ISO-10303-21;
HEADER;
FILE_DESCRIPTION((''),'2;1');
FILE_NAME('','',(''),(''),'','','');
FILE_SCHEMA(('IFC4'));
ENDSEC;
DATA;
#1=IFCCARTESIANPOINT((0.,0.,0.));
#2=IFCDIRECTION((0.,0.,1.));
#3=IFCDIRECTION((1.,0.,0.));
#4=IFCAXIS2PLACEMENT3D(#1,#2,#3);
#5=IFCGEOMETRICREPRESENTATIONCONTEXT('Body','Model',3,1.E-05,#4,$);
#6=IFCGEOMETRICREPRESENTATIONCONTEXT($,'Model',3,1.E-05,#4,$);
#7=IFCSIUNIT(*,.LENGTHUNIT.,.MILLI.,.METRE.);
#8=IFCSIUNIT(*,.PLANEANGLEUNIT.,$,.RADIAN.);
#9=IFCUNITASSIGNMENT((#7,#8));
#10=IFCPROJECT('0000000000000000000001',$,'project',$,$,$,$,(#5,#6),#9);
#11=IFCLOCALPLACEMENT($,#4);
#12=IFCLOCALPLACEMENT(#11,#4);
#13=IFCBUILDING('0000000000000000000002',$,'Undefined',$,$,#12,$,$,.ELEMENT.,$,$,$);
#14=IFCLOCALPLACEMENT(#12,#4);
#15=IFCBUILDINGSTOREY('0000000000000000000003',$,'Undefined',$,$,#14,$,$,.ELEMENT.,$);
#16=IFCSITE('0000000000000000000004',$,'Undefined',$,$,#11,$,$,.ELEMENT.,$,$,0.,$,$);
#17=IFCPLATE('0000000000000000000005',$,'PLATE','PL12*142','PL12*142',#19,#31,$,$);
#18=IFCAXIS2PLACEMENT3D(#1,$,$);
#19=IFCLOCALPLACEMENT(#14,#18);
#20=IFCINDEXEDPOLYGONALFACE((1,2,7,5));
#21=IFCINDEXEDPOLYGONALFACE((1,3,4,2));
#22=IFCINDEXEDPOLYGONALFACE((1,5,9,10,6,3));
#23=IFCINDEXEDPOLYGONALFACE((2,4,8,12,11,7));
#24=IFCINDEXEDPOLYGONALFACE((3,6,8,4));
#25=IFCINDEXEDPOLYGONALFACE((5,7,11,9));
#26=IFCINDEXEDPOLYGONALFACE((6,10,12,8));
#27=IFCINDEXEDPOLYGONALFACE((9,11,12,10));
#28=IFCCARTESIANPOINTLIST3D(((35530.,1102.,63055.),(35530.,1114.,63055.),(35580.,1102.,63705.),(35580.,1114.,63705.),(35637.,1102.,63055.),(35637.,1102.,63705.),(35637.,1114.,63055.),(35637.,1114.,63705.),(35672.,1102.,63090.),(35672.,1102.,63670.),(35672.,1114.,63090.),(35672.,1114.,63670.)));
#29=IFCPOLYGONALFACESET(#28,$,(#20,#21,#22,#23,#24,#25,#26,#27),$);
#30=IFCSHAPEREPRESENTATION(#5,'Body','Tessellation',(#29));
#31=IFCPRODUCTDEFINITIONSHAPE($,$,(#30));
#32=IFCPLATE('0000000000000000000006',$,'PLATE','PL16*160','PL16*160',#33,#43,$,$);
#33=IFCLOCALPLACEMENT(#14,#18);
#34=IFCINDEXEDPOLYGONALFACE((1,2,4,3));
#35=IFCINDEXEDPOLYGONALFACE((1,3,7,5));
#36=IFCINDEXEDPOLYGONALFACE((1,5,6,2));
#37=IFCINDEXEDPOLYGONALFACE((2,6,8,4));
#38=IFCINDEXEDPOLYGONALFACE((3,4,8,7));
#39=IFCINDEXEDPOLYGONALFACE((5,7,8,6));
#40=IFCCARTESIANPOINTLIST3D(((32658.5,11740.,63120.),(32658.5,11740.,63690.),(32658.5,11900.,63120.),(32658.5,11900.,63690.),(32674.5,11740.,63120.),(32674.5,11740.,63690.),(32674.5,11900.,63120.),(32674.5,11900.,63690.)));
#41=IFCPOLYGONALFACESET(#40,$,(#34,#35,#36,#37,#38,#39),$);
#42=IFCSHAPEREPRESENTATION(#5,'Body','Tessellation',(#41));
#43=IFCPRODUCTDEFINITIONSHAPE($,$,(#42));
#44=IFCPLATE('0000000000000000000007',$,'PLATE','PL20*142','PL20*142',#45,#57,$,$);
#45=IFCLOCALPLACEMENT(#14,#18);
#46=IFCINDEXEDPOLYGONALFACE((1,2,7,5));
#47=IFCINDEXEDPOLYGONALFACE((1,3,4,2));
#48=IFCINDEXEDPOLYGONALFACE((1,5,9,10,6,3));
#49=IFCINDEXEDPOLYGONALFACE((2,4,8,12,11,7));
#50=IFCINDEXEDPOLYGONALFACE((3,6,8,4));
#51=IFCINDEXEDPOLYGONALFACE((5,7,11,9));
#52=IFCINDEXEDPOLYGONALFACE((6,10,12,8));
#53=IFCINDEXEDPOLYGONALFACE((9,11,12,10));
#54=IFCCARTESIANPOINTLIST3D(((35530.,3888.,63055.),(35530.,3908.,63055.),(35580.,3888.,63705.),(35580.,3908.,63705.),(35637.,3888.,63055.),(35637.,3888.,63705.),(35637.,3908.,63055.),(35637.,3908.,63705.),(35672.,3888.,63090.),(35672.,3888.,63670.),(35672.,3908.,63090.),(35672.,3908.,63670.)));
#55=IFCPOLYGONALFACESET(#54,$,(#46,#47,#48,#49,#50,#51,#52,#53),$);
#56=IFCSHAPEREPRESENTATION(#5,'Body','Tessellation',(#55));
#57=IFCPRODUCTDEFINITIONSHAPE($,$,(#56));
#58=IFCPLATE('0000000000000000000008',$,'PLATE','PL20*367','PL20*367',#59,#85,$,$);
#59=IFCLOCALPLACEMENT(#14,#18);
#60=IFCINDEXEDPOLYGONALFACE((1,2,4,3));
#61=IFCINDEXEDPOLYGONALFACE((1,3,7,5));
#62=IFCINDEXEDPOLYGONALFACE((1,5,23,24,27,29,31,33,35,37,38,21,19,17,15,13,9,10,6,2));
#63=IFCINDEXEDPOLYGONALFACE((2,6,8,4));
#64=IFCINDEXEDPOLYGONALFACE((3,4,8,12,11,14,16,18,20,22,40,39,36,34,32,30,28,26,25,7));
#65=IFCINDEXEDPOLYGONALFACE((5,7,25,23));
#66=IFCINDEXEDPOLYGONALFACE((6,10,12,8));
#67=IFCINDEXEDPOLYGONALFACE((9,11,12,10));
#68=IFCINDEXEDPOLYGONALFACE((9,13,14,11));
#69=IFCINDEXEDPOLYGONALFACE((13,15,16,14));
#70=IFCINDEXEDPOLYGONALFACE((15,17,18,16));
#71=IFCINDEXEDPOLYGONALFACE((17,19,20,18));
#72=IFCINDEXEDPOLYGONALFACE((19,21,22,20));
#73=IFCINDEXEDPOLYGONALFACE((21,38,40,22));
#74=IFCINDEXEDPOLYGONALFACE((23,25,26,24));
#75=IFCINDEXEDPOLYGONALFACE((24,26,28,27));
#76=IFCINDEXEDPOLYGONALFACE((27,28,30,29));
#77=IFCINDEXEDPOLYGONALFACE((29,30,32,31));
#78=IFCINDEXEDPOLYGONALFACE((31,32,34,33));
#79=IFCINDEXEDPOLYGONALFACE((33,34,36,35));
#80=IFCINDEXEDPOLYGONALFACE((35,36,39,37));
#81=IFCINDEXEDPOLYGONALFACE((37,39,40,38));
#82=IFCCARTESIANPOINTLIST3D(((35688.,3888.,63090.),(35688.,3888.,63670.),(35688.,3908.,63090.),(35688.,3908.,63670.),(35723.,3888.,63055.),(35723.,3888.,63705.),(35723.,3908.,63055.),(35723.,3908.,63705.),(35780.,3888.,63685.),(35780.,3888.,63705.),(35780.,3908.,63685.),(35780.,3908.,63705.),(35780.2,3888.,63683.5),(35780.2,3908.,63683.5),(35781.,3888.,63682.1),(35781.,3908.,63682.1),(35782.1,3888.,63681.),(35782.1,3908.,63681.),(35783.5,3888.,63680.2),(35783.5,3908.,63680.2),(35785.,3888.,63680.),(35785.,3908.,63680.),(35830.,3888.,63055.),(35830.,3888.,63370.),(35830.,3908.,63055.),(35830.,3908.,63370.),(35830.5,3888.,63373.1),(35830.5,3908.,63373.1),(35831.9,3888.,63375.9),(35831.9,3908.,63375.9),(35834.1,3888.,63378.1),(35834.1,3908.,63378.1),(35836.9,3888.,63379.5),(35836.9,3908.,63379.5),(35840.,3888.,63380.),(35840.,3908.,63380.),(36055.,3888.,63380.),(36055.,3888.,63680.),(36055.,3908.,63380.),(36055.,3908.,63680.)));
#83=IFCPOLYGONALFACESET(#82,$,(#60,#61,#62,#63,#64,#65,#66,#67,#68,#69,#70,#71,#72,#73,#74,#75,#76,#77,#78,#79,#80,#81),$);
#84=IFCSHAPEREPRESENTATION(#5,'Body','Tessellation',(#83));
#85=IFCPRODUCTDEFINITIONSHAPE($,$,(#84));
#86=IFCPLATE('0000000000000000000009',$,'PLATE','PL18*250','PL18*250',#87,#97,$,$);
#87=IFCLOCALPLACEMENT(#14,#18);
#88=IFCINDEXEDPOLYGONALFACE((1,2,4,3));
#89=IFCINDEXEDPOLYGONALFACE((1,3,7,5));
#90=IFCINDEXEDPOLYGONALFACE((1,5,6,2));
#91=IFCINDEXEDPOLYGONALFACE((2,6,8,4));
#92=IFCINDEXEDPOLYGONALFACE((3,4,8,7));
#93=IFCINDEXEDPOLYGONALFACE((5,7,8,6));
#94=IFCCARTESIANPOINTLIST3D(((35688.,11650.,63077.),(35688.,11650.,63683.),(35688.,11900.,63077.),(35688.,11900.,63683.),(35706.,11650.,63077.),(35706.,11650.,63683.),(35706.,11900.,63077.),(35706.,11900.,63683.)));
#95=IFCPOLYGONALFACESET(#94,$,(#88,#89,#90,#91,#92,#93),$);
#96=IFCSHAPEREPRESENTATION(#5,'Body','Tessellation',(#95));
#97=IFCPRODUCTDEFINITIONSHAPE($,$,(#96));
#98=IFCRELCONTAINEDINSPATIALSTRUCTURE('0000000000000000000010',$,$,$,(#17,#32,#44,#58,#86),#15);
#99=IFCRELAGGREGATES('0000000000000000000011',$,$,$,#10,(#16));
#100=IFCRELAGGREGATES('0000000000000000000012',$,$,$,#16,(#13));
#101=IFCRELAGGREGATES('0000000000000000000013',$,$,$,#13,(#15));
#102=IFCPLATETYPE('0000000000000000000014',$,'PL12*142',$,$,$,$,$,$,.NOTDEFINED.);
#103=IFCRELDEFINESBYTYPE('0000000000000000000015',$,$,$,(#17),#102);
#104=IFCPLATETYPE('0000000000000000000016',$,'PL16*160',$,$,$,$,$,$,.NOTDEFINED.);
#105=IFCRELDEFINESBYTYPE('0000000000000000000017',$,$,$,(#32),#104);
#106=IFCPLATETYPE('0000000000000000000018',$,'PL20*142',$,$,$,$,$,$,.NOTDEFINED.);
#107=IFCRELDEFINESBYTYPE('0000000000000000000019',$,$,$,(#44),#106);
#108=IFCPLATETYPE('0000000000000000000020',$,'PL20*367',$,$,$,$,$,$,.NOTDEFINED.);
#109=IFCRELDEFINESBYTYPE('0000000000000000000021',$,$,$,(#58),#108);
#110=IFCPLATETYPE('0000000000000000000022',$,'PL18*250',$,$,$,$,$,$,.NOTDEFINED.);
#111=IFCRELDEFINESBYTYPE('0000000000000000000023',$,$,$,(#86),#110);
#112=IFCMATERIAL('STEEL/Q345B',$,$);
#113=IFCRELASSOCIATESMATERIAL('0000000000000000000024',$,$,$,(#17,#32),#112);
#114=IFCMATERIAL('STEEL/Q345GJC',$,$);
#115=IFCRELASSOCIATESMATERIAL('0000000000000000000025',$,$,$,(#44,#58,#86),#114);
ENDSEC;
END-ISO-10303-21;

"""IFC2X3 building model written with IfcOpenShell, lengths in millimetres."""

from ifc_helpers import new_model, si_unit, frame, origin_with_axes, place, context, project, spatial, polyline, outline, extrude, material, type_object, element, save


model = new_model("IFC2X3")

# Units and contexts
model_context_1 = context("Model", 3, precision=1e-05, world=origin_with_axes(), identifier="Body")
model_context_2 = context("Model", 3, precision=1e-05, world=origin_with_axes())
ifc_project = project(units=[si_unit("LENGTHUNIT", "METRE", prefix="MILLI"), si_unit("PLANEANGLEUNIT", "RADIAN")], contexts=[model_context_1, model_context_2])

# Site, building, storey
site_placement = place(None, origin_with_axes())
site = spatial("IfcSite", under=ifc_project, at=site_placement, Name="Undefined", CompositionType="ELEMENT", RefElevation=0.0)
building_placement = place(site_placement, origin_with_axes())
building = spatial("IfcBuilding", under=site, at=building_placement, Name="Undefined", CompositionType="ELEMENT")
storey_placement = place(building_placement, origin_with_axes())
storey = spatial("IfcBuildingStorey", under=building, at=storey_placement, Name="Undefined", CompositionType="ELEMENT")

# Shared definitions
ifc_material_1 = material(Name="STEEL/Q345B")
ifc_material_2 = material(Name="STEEL/Q345GJC")

# Plates
plate_type_1 = type_object("IfcPlateType", Name="PL12*142", PredefinedType="NOTDEFINED")
plate_1_placement = place(storey_placement, frame((35530.0, 1108.0, 63055.0), z_axis=(0.0, -1.0, 0.0), x_axis=(1.0, 0.0, 0.0)))
element("IfcPlate", 1, at=plate_1_placement, inside=storey, type_object=plate_type_1, material=ifc_material_1, Name="PLATE", Description="PL12*142", ObjectType="PL12*142", context=model_context_1, shape_type="SweptSolid", body=[
    extrude(outline(polyline([(0.0, 0.0), (107.0, 0.0), (142.0, 35.0), (142.0, 615.0), (107.0, 650.0), (50.0, 650.0), (0.0, 0.0)])), frame((0.0, 0.0, -6.0), z_axis=(0.0, 0.0, 1.0), x_axis=(1.0, 0.0, 0.0)), (0.0, 0.0, 1.0), 12.0),
])
plate_type_2 = type_object("IfcPlateType", Name="PL16*160", PredefinedType="NOTDEFINED")
plate_2_placement = place(storey_placement, frame((32666.5, 11740.0, 63690.0), z_axis=(-1.0, 0.0, 0.0), x_axis=(0.0, 1.0, 0.0)))
element("IfcPlate", 2, at=plate_2_placement, inside=storey, type_object=plate_type_2, material=ifc_material_1, Name="PLATE", Description="PL16*160", ObjectType="PL16*160", context=model_context_1, shape_type="SweptSolid", body=[
    extrude(outline(polyline([(0.0, 0.0), (160.0, 0.0), (160.0, 570.0), (0.0, 570.0), (0.0, 0.0)])), frame((0.0, 0.0, -8.0), z_axis=(0.0, 0.0, 1.0), x_axis=(1.0, 0.0, 0.0)), (0.0, 0.0, 1.0), 16.0),
])
plate_type_3 = type_object("IfcPlateType", Name="PL20*142", PredefinedType="NOTDEFINED")
plate_3_placement = place(storey_placement, frame((35530.0, 3898.0, 63055.0), z_axis=(0.0, -1.0, 0.0), x_axis=(1.0, 0.0, 0.0)))
element("IfcPlate", 3, at=plate_3_placement, inside=storey, type_object=plate_type_3, material=ifc_material_2, Name="PLATE", Description="PL20*142", ObjectType="PL20*142", context=model_context_1, shape_type="SweptSolid", body=[
    extrude(outline(polyline([(0.0, 0.0), (107.0, 0.0), (142.0, 35.0), (142.0, 615.0), (107.0, 650.0), (50.0, 650.0), (0.0, 0.0)])), frame((0.0, 0.0, -10.0), z_axis=(0.0, 0.0, 1.0), x_axis=(1.0, 0.0, 0.0)), (0.0, 0.0, 1.0), 20.0),
])
plate_type_4 = type_object("IfcPlateType", Name="PL20*367", PredefinedType="NOTDEFINED")
plate_4_placement = place(storey_placement, frame((35688.0, 3898.0, 63090.0), z_axis=(0.0, -1.0, 0.0), x_axis=(0.707107, 0.0, -0.707107)))
element("IfcPlate", 4, at=plate_4_placement, inside=storey, type_object=plate_type_4, material=ifc_material_2, Name="PLATE", Description="PL20*367", ObjectType="PL20*367", context=model_context_1, shape_type="SweptSolid", body=[
    extrude(outline(polyline([(0.0, 0.0), (49.5, 0.0), (125.2, 75.7), (-97.6, 298.4), (-99.4, 300.9), (-100.4, 303.9), (-100.4, 307.0), (-99.4, 310.0), (-97.6, 312.5), (54.4, 464.6), (-157.7, 676.7), (-348.6, 485.8), (-349.9, 484.9), (-351.4, 484.4), (-352.9, 484.4), (-354.4, 484.9), (-355.7, 485.8), (-369.8, 499.9), (-410.1, 459.6), (-410.1, 410.1), (0.0, 0.0)])), frame((0.0, 0.0, -10.0), z_axis=(0.0, 0.0, 1.0), x_axis=(1.0, 0.0, 0.0)), (0.0, 0.0, 1.0), 20.0),
])
plate_type_5 = type_object("IfcPlateType", Name="PL18*250", PredefinedType="NOTDEFINED")
plate_5_placement = place(storey_placement, frame((35697.0, 11650.0, 63683.0), z_axis=(-1.0, 0.0, 0.0), x_axis=(0.0, 1.0, 0.0)))
element("IfcPlate", 5, at=plate_5_placement, inside=storey, type_object=plate_type_5, material=ifc_material_2, Name="PLATE", Description="PL18*250", ObjectType="PL18*250", context=model_context_1, shape_type="SweptSolid", body=[
    extrude(outline(polyline([(0.0, 0.0), (250.0, 0.0), (250.0, 606.0), (0.0, 606.0), (0.0, 0.0)])), frame((0.0, 0.0, -9.0), z_axis=(0.0, 0.0, 1.0), x_axis=(1.0, 0.0, 0.0)), (0.0, 0.0, 1.0), 18.0),
])

save(model, "model.ifc")
